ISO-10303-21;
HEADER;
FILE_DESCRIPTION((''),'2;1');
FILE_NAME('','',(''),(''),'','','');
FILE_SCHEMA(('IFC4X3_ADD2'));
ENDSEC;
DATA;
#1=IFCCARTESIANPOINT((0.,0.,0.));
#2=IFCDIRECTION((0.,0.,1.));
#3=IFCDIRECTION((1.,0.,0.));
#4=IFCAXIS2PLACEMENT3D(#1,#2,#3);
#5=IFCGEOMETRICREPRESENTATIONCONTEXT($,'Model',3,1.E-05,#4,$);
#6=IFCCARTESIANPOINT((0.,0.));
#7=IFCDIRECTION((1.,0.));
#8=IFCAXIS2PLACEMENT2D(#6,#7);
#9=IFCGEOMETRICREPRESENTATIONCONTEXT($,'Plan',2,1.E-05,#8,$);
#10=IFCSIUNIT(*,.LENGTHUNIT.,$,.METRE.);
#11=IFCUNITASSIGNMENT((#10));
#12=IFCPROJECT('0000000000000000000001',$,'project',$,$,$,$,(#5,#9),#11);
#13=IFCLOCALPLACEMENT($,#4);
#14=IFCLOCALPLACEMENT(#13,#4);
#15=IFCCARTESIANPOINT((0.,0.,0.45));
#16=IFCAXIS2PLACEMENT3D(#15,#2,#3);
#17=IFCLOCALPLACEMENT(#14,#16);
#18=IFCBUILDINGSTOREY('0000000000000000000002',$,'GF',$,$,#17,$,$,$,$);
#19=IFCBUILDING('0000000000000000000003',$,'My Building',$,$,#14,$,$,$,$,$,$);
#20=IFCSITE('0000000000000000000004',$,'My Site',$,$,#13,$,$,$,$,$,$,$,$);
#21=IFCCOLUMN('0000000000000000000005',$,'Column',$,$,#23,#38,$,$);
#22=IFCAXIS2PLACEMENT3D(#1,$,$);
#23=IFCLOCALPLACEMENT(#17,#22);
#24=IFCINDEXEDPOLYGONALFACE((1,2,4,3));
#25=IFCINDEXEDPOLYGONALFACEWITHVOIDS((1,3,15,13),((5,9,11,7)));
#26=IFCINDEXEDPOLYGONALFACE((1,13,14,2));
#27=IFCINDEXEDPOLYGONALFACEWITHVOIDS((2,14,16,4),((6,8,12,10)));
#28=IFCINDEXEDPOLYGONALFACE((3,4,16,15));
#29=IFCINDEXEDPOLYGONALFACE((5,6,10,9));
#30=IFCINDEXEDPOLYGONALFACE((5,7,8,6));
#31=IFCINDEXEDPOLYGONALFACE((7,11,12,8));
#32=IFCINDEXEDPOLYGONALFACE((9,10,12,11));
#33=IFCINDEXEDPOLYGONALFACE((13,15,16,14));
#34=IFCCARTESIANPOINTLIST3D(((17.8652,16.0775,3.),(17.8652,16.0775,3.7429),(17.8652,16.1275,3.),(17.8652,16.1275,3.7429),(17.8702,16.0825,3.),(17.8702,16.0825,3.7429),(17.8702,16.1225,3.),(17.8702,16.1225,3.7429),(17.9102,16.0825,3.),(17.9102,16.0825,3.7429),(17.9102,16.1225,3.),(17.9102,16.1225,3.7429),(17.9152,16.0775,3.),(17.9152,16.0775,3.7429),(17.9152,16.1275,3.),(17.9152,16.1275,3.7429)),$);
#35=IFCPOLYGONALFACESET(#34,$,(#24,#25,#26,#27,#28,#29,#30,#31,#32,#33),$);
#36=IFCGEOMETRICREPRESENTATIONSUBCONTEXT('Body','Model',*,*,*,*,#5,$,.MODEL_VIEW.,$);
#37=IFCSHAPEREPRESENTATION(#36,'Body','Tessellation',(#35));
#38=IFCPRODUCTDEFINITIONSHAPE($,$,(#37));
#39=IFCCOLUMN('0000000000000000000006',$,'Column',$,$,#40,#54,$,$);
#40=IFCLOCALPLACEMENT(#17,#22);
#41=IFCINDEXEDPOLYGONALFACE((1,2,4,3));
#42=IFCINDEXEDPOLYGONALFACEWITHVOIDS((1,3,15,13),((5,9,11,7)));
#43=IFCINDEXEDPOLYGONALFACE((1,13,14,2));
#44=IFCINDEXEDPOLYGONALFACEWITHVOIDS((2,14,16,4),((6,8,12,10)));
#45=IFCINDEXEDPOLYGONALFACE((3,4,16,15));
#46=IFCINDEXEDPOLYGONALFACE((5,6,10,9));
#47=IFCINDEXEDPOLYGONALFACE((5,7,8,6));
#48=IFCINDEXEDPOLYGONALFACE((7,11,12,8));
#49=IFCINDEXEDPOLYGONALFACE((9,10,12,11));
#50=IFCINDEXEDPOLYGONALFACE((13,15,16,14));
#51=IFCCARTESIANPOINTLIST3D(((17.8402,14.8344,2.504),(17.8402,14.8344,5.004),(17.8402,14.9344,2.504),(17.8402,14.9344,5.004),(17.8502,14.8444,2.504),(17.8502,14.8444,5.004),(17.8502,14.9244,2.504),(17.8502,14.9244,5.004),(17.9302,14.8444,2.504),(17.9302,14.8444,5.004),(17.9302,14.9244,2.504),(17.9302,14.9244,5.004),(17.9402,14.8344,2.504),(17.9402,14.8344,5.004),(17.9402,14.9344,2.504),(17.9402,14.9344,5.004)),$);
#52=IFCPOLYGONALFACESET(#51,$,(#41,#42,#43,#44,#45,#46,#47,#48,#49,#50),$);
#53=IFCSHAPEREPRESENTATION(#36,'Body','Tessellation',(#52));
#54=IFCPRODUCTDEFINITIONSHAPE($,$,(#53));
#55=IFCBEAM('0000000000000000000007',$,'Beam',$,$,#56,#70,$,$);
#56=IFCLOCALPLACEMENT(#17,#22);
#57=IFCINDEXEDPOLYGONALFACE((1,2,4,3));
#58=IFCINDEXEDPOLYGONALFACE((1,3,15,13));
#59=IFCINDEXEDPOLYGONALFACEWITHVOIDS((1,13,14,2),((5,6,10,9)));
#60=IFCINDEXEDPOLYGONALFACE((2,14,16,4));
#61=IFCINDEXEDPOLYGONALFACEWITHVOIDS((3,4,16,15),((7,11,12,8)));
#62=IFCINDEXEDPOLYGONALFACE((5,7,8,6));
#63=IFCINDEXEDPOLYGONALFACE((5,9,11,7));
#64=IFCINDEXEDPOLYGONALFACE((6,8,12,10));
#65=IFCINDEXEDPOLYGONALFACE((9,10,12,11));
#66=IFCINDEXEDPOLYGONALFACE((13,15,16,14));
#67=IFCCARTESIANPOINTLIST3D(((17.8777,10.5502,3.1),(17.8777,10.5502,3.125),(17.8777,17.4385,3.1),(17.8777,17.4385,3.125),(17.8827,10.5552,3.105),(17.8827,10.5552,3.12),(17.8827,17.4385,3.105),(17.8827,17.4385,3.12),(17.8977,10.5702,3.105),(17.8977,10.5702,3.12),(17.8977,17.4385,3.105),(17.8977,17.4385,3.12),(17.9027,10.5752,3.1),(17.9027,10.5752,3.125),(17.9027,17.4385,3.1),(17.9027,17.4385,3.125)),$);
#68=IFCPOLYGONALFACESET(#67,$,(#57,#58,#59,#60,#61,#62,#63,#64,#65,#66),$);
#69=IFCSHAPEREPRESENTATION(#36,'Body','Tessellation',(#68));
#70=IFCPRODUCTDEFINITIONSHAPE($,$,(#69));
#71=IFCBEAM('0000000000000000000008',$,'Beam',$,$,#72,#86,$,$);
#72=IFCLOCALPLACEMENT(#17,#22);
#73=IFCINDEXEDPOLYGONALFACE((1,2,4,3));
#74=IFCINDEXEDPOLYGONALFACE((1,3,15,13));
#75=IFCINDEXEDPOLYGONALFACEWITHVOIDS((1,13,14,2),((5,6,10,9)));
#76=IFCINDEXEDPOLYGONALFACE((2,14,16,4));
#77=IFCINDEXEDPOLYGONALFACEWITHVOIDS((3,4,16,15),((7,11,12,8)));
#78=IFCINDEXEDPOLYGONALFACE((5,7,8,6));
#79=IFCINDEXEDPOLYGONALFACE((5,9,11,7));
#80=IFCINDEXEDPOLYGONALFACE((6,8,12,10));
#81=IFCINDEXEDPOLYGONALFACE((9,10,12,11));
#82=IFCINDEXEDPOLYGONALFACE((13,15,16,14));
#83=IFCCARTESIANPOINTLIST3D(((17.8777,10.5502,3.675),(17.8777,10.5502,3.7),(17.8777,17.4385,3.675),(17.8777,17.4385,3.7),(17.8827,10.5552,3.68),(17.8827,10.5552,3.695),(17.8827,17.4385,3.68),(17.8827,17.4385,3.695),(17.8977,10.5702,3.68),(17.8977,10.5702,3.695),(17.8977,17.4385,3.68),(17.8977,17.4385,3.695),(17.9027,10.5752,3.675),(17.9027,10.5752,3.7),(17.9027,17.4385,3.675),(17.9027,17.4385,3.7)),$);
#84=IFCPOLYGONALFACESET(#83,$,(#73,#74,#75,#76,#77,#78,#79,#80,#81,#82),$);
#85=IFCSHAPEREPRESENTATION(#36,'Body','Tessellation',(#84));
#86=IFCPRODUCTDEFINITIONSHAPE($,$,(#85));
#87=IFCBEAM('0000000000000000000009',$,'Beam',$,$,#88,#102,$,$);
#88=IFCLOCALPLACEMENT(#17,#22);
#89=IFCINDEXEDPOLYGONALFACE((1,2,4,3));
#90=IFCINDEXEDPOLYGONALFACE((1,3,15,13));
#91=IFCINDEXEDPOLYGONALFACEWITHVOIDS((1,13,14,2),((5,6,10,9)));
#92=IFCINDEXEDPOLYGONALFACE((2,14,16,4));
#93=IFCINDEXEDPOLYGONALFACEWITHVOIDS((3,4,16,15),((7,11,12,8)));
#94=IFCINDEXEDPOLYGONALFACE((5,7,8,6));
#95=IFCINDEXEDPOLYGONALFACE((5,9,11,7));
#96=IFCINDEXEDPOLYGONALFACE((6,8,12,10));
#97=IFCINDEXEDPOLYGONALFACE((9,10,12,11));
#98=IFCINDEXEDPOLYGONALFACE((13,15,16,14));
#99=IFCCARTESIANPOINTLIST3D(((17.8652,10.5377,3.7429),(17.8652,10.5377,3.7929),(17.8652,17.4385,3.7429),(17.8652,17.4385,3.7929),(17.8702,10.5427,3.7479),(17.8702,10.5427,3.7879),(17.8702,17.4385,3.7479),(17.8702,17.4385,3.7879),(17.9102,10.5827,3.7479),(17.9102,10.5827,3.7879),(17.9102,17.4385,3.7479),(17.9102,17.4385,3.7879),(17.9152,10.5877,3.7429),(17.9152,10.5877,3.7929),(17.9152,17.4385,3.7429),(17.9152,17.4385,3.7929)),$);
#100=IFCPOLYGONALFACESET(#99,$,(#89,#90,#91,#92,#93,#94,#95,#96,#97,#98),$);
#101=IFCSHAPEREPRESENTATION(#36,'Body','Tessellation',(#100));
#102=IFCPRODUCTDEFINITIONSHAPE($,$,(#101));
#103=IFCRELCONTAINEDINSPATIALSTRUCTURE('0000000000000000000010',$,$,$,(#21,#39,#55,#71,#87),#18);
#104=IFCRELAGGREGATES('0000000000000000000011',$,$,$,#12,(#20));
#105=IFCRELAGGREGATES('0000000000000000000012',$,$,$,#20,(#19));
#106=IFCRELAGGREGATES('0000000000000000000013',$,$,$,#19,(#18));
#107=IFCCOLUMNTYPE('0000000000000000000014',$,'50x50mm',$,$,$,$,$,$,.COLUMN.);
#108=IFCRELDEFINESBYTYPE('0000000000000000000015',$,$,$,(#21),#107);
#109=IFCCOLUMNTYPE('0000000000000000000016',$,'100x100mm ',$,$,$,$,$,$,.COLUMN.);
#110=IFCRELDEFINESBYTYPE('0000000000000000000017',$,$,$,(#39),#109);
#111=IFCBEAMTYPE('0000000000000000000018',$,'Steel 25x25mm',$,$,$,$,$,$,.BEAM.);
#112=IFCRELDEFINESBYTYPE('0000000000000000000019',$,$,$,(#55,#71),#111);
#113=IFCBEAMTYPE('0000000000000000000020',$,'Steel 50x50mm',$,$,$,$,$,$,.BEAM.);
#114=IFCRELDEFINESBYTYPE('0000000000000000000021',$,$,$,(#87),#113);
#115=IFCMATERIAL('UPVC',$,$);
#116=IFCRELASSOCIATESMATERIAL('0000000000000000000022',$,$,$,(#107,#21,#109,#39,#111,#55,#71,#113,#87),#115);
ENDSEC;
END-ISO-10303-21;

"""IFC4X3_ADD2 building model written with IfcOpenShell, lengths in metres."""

from ifc_helpers import new_model, entity, si_unit, frame, origin_with_axes, origin_2d_with_axis, place, context, subcontext, project, spatial, hollow_rectangle, extrude, clip, halfspace, shape, material, material_profile, profile_set, profile_usage, type_object, element, save


model = new_model("IFC4X3_ADD2")

# Units and contexts
model_context = context("Model", 3, precision=1e-05, world=origin_with_axes())
plan_context = context("Plan", 2, precision=1e-05, world=origin_2d_with_axis())
body_context_1 = subcontext(model_context, "Body", "Model", "MODEL_VIEW")
body_context_2 = subcontext(plan_context, "Body", "Plan", "PLAN_VIEW")
ifc_project = project(units=[si_unit("LENGTHUNIT", "METRE")], contexts=[model_context, plan_context])

# Site, building, storey
site_placement = place(None, origin_with_axes())
site = spatial("IfcSite", under=ifc_project, at=site_placement, Name="My Site")
building_placement = place(site_placement, origin_with_axes())
building = spatial("IfcBuilding", under=site, at=building_placement, Name="My Building")
storey_placement = place(building_placement, frame((0.0, 0.0, 0.45), z_axis=(0.0, 0.0, 1.0), x_axis=(1.0, 0.0, 0.0)))
storey = spatial("IfcBuildingStorey", under=building, at=storey_placement, Name="GF")

# Columns
ifc_material_1 = material(Name="UPVC")
ifc_material_profile_1 = material_profile(ifc_material_1, hollow_rectangle(XDim=0.05, YDim=0.05, WallThickness=0.005))
ifc_profile_set_1 = profile_set([ifc_material_profile_1])
column_type_1 = type_object("IfcColumnType", Name="50x50mm", PredefinedType="COLUMN", material=ifc_profile_set_1)
ifc_profile_usage_1 = profile_usage(ifc_profile_set_1)
column_1_placement = place(storey_placement, frame((17.8902, 16.1025, 3.0), z_axis=(0.0, 0.0, 1.0), x_axis=(0.0, -1.0, 0.0)))
element("IfcColumn", 1, at=column_1_placement, inside=storey, type_object=column_type_1, material=ifc_profile_usage_1, Name="Column", context=body_context_1, shape_type="SweptSolid", body=[
    extrude(hollow_rectangle(XDim=0.05, YDim=0.05, WallThickness=0.005), origin_with_axes(), (0.0, 0.0, 1.0), 0.7429),
])
ifc_material_profile_2 = material_profile(ifc_material_1, hollow_rectangle(XDim=0.1, YDim=0.1, WallThickness=0.01))
ifc_profile_set_2 = profile_set([ifc_material_profile_2])
ifc_profile_usage_2 = profile_usage(ifc_profile_set_2)
column_type_2 = type_object("IfcColumnType", Name="100x100mm ", PredefinedType="COLUMN", material=ifc_profile_set_2)
column_2_placement = place(storey_placement, frame((17.8902, 14.8844, 2.504), z_axis=(0.0, 0.0, 1.0), x_axis=(0.0, -1.0, 0.0)))
element("IfcColumn", 2, at=column_2_placement, inside=storey, type_object=column_type_2, material=ifc_profile_usage_2, Name="Column", shapes=[
    shape(body_context_1, "Body", "SweptSolid", [extrude(hollow_rectangle(XDim=0.1, YDim=0.1, WallThickness=0.01), origin_with_axes(), (0.0, 0.0, 1.0), 2.5)]),
    shape(body_context_2, "Body", "Annotation2D", [entity("IfcGeometricCurveSet", [entity("IfcIndexedPolyCurve", entity("IfcCartesianPointList2D", [[0.04, -0.04], [0.04, 0.04], [-0.04, 0.04], [-0.04, -0.04]]), [entity("IfcLineIndex", [1, 2, 3, 4, 1])]), entity("IfcIndexedPolyCurve", entity("IfcCartesianPointList2D", [[-0.05, -0.05], [-0.05, 0.05], [0.05, 0.05], [0.05, -0.05]]), [entity("IfcLineIndex", [1, 2, 3, 4, 1])])])]),
])

# Beams
ifc_material_profile_3 = material_profile(ifc_material_1, hollow_rectangle(XDim=0.025, YDim=0.025, WallThickness=0.005))
ifc_profile_set_3 = profile_set([ifc_material_profile_3])
ifc_profile_usage_3 = profile_usage(ifc_profile_set_3)
beam_type_1 = type_object("IfcBeamType", Name="Steel 25x25mm", PredefinedType="BEAM", material=ifc_profile_set_3)
beam_1_placement = place(storey_placement, frame((17.8902, 17.4385, 3.1125), z_axis=(0.0, -1.0, 0.0), x_axis=(1.0, 0.0, 0.0)))
element("IfcBeam", 3, at=beam_1_placement, inside=storey, type_object=beam_type_1, material=ifc_profile_usage_3, Name="Beam", context=body_context_1, shape_type="Clipping", body=[
    clip(extrude(hollow_rectangle(XDim=0.025, YDim=0.025, WallThickness=0.005), origin_with_axes(), (0.0, 0.0, 1.0), 6.8883), halfspace(frame((-0.0125, -3.5625, 6.8883), z_axis=(0.70708, 0.0, 0.707134), x_axis=(0.0, -1.0, 0.0)), False)),
])
ifc_profile_usage_4 = profile_usage(ifc_profile_set_3)
beam_2_placement = place(storey_placement, frame((17.8902, 17.4385, 3.6875), z_axis=(0.0, -1.0, 0.0), x_axis=(1.0, 0.0, 0.0)))
element("IfcBeam", 4, at=beam_2_placement, inside=storey, type_object=beam_type_1, material=ifc_profile_usage_4, Name="Beam", context=body_context_1, shape_type="Clipping", body=[
    clip(extrude(hollow_rectangle(XDim=0.025, YDim=0.025, WallThickness=0.005), origin_with_axes(), (0.0, 0.0, 1.0), 6.8883), halfspace(frame((-0.0125, -4.1375, 6.8883), z_axis=(0.70708, 0.0, 0.707134), x_axis=(0.0, -1.0, 0.0)), False)),
])
ifc_material_profile_4 = material_profile(ifc_material_1, hollow_rectangle(XDim=0.05, YDim=0.05, WallThickness=0.005))
ifc_profile_set_4 = profile_set([ifc_material_profile_4])
ifc_profile_usage_5 = profile_usage(ifc_profile_set_4)
beam_type_2 = type_object("IfcBeamType", Name="Steel 50x50mm", PredefinedType="BEAM", material=ifc_profile_set_4)
beam_3_placement = place(storey_placement, frame((17.8902, 17.4385, 3.7679), z_axis=(0.0, -1.0, 0.0), x_axis=(1.0, 0.0, 0.0)))
element("IfcBeam", 5, at=beam_3_placement, inside=storey, type_object=beam_type_2, material=ifc_profile_usage_5, Name="Beam", context=body_context_1, shape_type="Clipping", body=[
    clip(extrude(hollow_rectangle(XDim=0.05, YDim=0.05, WallThickness=0.005), origin_with_axes(), (0.0, 0.0, 1.0), 6.9008), halfspace(frame((-0.025, -4.2179, 6.9008), z_axis=(0.707107, 0.0, 0.707107), x_axis=(0.0, -1.0, 0.0)), False)),
])

save(model, "model.ifc")
